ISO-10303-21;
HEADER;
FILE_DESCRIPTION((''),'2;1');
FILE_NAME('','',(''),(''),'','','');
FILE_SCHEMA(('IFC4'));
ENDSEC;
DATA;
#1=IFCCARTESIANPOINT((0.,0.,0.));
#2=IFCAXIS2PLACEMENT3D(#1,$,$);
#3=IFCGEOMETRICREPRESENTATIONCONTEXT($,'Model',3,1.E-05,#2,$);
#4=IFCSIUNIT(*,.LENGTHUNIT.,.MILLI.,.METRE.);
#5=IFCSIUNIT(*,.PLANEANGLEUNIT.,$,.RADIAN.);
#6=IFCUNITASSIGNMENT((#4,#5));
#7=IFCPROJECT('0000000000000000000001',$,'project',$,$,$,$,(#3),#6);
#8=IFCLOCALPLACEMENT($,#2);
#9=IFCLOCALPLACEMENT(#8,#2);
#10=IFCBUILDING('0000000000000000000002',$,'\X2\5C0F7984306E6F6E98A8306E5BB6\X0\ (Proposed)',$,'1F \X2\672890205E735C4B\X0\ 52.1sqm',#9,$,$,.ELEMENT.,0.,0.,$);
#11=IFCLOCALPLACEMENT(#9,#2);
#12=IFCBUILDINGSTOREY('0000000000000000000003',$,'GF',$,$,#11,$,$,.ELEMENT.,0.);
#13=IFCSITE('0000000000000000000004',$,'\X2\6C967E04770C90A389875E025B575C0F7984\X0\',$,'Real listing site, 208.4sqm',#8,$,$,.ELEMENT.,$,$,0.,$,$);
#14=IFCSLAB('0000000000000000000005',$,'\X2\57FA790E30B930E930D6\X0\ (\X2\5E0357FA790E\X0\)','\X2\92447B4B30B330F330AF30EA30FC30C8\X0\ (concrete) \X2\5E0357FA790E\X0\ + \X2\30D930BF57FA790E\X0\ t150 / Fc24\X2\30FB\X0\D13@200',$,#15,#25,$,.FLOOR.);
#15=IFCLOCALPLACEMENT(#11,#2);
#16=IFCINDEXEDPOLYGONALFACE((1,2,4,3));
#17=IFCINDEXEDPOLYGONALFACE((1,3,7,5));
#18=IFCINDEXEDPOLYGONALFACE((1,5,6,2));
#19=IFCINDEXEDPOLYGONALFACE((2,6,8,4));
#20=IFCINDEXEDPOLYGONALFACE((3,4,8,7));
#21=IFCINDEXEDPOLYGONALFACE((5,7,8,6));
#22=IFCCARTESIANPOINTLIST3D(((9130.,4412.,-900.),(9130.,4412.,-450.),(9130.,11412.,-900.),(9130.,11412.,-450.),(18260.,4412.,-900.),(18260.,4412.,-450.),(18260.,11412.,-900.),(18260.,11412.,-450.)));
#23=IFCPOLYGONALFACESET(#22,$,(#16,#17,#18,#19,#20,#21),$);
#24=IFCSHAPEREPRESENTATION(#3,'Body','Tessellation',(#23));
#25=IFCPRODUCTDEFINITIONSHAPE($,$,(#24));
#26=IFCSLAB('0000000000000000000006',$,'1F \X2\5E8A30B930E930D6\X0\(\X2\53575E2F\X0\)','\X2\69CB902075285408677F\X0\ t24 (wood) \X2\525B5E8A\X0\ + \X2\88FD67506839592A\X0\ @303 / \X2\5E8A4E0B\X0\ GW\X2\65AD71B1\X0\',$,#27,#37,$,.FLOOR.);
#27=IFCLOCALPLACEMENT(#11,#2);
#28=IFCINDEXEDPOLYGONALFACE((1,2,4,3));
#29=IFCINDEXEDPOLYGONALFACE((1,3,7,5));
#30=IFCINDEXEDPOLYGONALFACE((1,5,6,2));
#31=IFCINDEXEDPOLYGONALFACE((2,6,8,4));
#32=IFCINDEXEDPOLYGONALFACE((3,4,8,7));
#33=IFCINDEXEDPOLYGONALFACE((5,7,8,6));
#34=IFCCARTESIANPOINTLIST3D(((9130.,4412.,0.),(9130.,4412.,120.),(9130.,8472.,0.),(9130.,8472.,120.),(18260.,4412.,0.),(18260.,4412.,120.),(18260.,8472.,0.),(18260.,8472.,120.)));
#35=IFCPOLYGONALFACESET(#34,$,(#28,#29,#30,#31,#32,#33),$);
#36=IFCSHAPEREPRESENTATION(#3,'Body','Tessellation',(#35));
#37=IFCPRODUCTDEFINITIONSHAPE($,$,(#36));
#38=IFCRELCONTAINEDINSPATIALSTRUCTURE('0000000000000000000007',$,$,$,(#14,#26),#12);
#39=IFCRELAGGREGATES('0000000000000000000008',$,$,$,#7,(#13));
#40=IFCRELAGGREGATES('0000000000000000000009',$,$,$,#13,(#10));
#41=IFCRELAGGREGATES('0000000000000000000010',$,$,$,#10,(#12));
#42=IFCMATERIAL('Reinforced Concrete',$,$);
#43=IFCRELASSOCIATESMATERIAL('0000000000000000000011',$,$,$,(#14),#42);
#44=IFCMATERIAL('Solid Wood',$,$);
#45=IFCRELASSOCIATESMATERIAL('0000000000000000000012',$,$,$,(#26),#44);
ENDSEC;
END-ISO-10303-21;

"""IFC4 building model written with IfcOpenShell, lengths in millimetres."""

from ifc_helpers import new_model, si_unit, frame, frame_2d, origin, place, context, project, spatial, rectangle, extrude, material, element, save


model = new_model("IFC4")

# Units and contexts
model_context = context("Model", 3, precision=1e-05, world=origin())
ifc_project = project(units=[si_unit("LENGTHUNIT", "METRE", prefix="MILLI"), si_unit("PLANEANGLEUNIT", "RADIAN")], contexts=[model_context])

# Site, building, storey
site_placement = place(None, origin())
site = spatial("IfcSite", under=ifc_project, at=site_placement, Name="沖縄県那覇市字小禄", ObjectType="Real listing site, 208.4sqm", CompositionType="ELEMENT", RefElevation=0.0)
building_placement = place(site_placement, origin())
building = spatial("IfcBuilding", under=site, at=building_placement, Name="小禄の潮風の家 (Proposed)", ObjectType="1F 木造平屋 52.1sqm", CompositionType="ELEMENT", ElevationOfRefHeight=0.0, ElevationOfTerrain=0.0)
storey_placement = place(building_placement, origin())
storey = spatial("IfcBuildingStorey", under=building, at=storey_placement, Name="GF", CompositionType="ELEMENT", Elevation=0.0)

# Shared definitions
ifc_material_1 = material(Name="Solid Wood")

# Slabs
ifc_material_2 = material(Name="Reinforced Concrete")
slab_1_placement = place(storey_placement, frame((4565.0, 2206.0, -450.0)))
element("IfcSlab", 1, at=slab_1_placement, inside=storey, material=ifc_material_2, Name="基礎スラブ (布基礎)", Description="鉄筋コンクリート (concrete) 布基礎 + ベタ基礎 t150 / Fc24・D13@200", PredefinedType="FLOOR", context=model_context, shape_type="SweptSolid", body=[
    extrude(rectangle(XDim=9130.0, YDim=7000.0, at=frame_2d((4565.0, 3500.0))), frame((4565.0, 2206.0, -450.0)), (0.0, 0.0, 1.0), 450.0),
])
slab_2_placement = place(storey_placement, frame((4565.0, 2206.0, 0.0)))
element("IfcSlab", 2, at=slab_2_placement, inside=storey, material=ifc_material_1, Name="1F 床スラブ(南帯)", Description="構造用合板 t24 (wood) 剛床 + 製材根太 @303 / 床下 GW断熱", PredefinedType="FLOOR", context=model_context, shape_type="SweptSolid", body=[
    extrude(rectangle(XDim=9130.0, YDim=4060.0, at=frame_2d((4565.0, 2030.0))), frame((4565.0, 2206.0, 0.0)), (0.0, 0.0, 1.0), 120.0),
])

save(model, "model.ifc")
